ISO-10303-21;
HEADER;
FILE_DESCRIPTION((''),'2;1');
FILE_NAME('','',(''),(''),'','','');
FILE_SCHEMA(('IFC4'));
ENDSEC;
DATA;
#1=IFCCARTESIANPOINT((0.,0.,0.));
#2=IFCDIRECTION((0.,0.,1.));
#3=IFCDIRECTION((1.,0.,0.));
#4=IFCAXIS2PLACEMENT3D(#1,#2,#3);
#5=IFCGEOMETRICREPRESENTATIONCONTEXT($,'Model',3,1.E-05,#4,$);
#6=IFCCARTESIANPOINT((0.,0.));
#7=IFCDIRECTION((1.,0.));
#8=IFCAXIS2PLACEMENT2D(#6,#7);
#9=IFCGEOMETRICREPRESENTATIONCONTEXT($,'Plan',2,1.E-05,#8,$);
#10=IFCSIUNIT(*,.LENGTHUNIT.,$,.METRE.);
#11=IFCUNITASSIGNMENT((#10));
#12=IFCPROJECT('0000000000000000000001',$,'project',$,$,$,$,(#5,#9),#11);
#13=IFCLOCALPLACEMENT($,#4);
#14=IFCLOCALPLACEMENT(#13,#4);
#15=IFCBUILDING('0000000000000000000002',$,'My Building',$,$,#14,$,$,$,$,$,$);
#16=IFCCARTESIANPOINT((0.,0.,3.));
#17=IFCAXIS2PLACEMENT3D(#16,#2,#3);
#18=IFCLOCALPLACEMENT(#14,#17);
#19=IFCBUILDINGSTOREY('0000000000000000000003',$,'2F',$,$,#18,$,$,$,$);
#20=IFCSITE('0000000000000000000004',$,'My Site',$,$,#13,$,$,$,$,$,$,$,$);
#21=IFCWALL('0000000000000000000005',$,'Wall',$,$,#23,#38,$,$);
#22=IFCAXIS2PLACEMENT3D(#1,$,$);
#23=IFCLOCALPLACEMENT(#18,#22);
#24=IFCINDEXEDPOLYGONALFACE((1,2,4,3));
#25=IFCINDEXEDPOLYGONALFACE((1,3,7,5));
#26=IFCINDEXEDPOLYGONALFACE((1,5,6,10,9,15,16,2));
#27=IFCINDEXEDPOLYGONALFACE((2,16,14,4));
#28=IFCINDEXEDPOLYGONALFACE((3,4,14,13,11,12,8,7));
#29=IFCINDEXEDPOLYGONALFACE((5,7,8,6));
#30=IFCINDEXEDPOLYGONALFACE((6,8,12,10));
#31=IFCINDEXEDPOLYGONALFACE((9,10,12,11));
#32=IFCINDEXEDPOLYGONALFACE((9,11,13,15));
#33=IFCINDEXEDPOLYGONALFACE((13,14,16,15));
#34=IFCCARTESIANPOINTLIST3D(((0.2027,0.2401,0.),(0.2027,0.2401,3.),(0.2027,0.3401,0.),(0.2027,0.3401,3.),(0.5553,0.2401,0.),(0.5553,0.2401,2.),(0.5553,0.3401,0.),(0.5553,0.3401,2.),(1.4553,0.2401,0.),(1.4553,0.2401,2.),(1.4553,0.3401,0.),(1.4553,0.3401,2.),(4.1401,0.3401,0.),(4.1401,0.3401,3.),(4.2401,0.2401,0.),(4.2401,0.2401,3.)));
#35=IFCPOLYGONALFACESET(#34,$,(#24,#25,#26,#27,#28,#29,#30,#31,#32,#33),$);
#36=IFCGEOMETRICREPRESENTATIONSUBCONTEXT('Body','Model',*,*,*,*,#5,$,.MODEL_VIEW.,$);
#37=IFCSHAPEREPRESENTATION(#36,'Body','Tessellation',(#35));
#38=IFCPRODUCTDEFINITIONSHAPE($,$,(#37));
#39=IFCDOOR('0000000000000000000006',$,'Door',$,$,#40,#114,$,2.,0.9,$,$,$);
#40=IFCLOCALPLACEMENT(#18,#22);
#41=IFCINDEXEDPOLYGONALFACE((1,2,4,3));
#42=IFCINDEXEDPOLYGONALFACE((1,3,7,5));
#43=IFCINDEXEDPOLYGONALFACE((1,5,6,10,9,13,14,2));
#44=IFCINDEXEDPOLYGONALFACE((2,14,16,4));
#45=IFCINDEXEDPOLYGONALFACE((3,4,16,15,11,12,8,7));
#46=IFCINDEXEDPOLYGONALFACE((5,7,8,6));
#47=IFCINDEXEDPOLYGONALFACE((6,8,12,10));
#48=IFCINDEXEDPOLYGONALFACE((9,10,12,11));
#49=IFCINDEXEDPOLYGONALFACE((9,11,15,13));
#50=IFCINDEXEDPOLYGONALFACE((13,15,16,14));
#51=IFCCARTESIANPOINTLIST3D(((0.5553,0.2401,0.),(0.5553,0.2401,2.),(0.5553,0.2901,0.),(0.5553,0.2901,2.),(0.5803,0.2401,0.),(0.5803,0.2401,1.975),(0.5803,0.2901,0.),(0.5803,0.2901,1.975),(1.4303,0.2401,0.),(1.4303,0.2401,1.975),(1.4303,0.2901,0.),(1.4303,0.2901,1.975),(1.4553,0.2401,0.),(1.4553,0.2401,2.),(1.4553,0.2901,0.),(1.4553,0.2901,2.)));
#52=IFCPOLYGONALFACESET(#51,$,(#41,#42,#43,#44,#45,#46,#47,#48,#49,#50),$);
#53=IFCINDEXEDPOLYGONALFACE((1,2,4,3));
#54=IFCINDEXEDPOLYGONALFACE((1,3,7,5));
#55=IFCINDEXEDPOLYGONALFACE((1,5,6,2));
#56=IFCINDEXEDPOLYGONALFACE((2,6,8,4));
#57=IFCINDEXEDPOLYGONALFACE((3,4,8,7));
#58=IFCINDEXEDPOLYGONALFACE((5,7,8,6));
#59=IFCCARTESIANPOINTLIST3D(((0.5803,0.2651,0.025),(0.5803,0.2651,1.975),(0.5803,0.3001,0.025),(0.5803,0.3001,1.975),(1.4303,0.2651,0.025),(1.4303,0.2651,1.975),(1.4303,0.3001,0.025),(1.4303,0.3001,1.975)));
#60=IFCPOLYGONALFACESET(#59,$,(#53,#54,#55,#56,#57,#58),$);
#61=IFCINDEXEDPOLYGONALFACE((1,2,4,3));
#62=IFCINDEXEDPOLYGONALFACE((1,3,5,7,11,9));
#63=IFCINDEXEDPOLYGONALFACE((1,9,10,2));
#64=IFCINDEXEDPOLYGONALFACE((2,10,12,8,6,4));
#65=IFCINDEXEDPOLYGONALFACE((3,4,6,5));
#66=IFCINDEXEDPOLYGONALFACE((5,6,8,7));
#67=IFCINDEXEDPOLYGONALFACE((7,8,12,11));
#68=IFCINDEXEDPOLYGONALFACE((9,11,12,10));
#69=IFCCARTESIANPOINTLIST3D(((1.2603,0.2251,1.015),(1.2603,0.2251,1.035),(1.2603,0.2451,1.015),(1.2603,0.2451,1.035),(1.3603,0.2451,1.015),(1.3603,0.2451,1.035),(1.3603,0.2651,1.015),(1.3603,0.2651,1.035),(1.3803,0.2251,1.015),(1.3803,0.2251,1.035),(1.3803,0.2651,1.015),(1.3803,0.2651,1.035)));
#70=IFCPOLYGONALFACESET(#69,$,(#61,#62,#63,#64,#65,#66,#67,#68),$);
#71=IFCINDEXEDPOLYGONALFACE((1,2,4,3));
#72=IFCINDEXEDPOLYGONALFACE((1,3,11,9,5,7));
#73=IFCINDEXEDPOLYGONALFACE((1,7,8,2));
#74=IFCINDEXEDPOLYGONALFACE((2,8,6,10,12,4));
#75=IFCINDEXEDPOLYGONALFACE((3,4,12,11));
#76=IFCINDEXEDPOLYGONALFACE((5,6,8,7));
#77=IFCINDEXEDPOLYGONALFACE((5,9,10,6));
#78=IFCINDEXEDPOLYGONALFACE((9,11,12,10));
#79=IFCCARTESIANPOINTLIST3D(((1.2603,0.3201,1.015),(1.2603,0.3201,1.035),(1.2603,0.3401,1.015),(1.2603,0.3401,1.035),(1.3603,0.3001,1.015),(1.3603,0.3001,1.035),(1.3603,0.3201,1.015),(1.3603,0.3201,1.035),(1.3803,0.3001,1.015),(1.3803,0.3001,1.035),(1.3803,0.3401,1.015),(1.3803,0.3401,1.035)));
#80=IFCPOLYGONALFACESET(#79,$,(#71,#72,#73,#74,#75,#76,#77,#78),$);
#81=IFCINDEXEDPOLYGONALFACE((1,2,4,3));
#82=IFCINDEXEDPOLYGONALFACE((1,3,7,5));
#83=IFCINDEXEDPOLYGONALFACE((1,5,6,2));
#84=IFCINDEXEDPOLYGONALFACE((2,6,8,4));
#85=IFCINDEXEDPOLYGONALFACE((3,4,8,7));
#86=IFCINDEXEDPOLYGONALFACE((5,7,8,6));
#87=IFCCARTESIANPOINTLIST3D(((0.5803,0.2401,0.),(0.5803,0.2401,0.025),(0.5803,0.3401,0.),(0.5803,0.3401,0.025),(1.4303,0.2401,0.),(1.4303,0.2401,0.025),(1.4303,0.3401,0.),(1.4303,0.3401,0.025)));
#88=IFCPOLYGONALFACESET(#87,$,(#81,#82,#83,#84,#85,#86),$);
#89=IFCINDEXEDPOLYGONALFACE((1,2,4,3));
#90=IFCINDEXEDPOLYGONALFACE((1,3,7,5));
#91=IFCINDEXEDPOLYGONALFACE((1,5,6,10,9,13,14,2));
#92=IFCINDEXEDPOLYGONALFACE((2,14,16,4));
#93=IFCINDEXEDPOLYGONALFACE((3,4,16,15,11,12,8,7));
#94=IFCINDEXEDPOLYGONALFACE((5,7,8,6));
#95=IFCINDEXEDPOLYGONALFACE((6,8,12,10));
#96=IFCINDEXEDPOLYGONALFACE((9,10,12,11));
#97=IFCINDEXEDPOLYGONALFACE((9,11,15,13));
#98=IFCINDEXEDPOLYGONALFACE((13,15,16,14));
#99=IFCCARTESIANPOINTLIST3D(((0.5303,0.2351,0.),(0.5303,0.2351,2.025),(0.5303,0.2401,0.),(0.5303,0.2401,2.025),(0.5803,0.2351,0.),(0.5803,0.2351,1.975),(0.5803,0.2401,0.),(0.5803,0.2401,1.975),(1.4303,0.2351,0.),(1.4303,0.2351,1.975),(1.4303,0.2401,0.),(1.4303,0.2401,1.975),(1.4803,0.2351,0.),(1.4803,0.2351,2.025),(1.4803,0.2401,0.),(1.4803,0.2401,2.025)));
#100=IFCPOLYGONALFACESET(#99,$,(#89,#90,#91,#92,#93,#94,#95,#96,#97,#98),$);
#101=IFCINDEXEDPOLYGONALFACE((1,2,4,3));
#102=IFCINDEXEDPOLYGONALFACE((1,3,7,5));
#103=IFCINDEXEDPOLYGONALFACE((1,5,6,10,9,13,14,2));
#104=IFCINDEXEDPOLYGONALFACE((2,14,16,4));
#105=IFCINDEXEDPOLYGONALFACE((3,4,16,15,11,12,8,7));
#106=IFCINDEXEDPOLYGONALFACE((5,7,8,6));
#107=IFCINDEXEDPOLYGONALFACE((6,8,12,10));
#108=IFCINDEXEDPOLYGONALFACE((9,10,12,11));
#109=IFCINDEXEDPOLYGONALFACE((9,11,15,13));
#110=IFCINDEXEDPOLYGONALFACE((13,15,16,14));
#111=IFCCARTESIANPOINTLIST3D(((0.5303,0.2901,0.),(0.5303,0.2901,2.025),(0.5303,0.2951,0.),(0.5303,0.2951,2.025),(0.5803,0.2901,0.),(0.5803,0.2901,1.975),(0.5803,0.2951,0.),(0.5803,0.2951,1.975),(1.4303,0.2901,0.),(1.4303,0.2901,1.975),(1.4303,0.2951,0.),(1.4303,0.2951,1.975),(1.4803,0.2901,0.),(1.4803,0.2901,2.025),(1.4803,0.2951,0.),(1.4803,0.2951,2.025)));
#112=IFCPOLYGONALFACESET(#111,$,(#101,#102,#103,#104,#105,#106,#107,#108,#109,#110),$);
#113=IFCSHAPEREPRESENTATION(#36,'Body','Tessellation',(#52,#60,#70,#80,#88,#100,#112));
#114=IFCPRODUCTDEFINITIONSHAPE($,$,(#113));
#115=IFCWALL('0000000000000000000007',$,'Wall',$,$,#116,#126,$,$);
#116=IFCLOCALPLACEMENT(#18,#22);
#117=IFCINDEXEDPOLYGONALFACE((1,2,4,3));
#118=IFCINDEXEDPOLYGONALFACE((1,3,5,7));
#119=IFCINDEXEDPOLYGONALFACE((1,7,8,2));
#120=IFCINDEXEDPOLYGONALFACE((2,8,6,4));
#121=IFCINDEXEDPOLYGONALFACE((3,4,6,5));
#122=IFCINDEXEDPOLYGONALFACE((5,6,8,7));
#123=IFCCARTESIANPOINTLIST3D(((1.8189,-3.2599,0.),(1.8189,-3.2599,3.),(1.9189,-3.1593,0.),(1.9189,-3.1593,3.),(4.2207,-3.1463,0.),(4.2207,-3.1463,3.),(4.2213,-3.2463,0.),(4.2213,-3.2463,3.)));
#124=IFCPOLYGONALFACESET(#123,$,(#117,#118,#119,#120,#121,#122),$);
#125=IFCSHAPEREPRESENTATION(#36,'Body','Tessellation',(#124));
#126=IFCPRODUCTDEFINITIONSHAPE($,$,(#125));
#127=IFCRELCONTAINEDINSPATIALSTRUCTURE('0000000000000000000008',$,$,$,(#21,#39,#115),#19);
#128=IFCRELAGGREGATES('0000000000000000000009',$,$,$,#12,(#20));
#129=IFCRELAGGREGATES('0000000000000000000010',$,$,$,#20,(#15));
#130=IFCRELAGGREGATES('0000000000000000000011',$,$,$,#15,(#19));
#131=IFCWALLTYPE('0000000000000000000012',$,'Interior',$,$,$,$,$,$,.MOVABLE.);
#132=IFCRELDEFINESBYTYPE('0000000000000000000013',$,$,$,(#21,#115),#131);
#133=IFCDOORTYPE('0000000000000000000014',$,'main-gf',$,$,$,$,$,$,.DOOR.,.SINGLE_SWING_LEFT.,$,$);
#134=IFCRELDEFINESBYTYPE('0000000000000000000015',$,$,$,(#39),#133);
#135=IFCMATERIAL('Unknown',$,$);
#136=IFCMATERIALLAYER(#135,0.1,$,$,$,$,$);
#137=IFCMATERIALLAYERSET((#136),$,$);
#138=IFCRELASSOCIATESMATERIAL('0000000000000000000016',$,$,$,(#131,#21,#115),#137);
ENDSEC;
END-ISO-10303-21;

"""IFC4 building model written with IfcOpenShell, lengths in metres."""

from ifc_helpers import new_model, entity, si_unit, frame, origin_with_axes, origin_2d_with_axis, place, context, subcontext, project, spatial, line, indexed_curve, outline, extrude, shape, source, transform, mapped, material, layer, layer_set, layer_usage, type_object, type_shapes, element, fill, save


model = new_model("IFC4")

# Units and contexts
model_context = context("Model", 3, precision=1e-05, world=origin_with_axes())
plan_context = context("Plan", 2, precision=1e-05, world=origin_2d_with_axis())
body_context_1 = subcontext(model_context, "Body", "Model", "MODEL_VIEW")
body_context_2 = subcontext(plan_context, "Body", "Plan", "PLAN_VIEW")
ifc_project = project(units=[si_unit("LENGTHUNIT", "METRE")], contexts=[model_context, plan_context])

# Site, building, storey
site_placement = place(None, origin_with_axes())
site = spatial("IfcSite", under=ifc_project, at=site_placement, Name="My Site")
building_placement = place(site_placement, origin_with_axes())
building = spatial("IfcBuilding", under=site, at=building_placement, Name="My Building")
storey_placement = place(building_placement, frame((0.0, 0.0, 3.0), z_axis=(0.0, 0.0, 1.0), x_axis=(1.0, 0.0, 0.0)))
storey = spatial("IfcBuildingStorey", under=building, at=storey_placement, Name="2F")

# Shared definitions
ifc_material = material(Name="Unknown")

# Shared definitions
ifc_layer_1 = layer(ifc_material, 0.1)
ifc_layer_set_1 = layer_set([ifc_layer_1])
wall_type = type_object("IfcWallType", Name="Interior", PredefinedType="MOVABLE", material=ifc_layer_set_1)

# Shared definitions
shared_shape_1 = source(origin_with_axes(), body_context_1, "Body", "SweptSolid", [
    extrude(outline(indexed_curve([(0.0, 0.0), (0.9, 0.0), (0.9, 2.0), (0.0, 2.0)], segments=[line(1, 2, 3, 4, 1)])), frame((0.0, -0.6, 0.0), z_axis=(0.0, -1.0, 0.0), x_axis=(1.0, 0.0, 0.0)), (0.0, 0.0, -1.0), 1.2),
])
door_type = type_object("IfcDoorType", Name="main-gf", OperationType="SINGLE_SWING_LEFT", PredefinedType="DOOR")
shared_shape_2 = source(origin_with_axes(), body_context_1, "Body", "SweptSolid", [
    extrude(outline(indexed_curve([(0.0, 0.0), (0.0, 2.0), (0.9, 2.0), (0.9, 0.0), (0.875, 0.0), (0.875, 1.975), (0.025, 1.975), (0.025, 0.0)], segments=[line(1, 2, 3, 4, 5, 6, 7, 8, 1)])), frame((0.0, 0.0, 0.0), z_axis=(0.0, -1.0, 0.0), x_axis=(1.0, 0.0, 0.0)), (0.0, 0.0, -1.0), 0.05),
    extrude(outline(indexed_curve([(0.0, 0.0), (0.85, 0.0), (0.85, 0.035), (0.0, 0.035)], segments=[line(1, 2, 3, 4, 1)])), frame((0.025, 0.025, 0.025), z_axis=(0.0, 0.0, 1.0), x_axis=(1.0, 0.0, 0.0)), (0.0, 0.0, 1.0), 1.95),
    extrude(outline(indexed_curve([(0.0, 0.0), (0.0, -0.04), (-0.12, -0.04), (-0.12, -0.02), (-0.02, -0.02), (-0.02, 0.0)], segments=[line(1, 2, 3, 4, 5, 6, 1)])), frame((0.825, 0.025, 1.015), z_axis=(0.0, 0.0, 1.0), x_axis=(1.0, 0.0, 0.0)), (0.0, 0.0, 1.0), 0.02),
    extrude(outline(indexed_curve([(0.0, 0.0), (0.0, 0.04), (-0.12, 0.04), (-0.12, 0.02), (-0.02, 0.02), (-0.02, 0.0)], segments=[line(1, 2, 3, 4, 5, 6, 1)])), frame((0.825, 0.06, 1.015), z_axis=(0.0, 0.0, 1.0), x_axis=(1.0, 0.0, 0.0)), (0.0, 0.0, 1.0), 0.02),
    extrude(outline(indexed_curve([(0.0, 0.0), (0.85, 0.0), (0.85, 0.1), (0.0, 0.1)], segments=[line(1, 2, 3, 4, 1)])), frame((0.025, 0.0, 0.0), z_axis=(0.0, 0.0, 1.0), x_axis=(1.0, 0.0, 0.0)), (0.0, 0.0, 1.0), 0.025),
    extrude(outline(indexed_curve([(0.0, 0.0), (0.0, 2.025), (0.95, 2.025), (0.95, 0.0), (0.9, 0.0), (0.9, 1.975), (0.05, 1.975), (0.05, 0.0)], segments=[line(1, 2, 3, 4, 5, 6, 7, 8, 1)])), frame((-0.025, -0.005, 0.0), z_axis=(0.0, -1.0, 0.0), x_axis=(1.0, 0.0, 0.0)), (0.0, 0.0, -1.0), 0.005),
    extrude(outline(indexed_curve([(0.0, 0.0), (0.0, 2.025), (0.95, 2.025), (0.95, 0.0), (0.9, 0.0), (0.9, 1.975), (0.05, 1.975), (0.05, 0.0)], segments=[line(1, 2, 3, 4, 5, 6, 7, 8, 1)])), frame((-0.025, 0.05, 0.0), z_axis=(0.0, -1.0, 0.0), x_axis=(1.0, 0.0, 0.0)), (0.0, 0.0, -1.0), 0.005),
])
shared_shape_3 = source(origin_with_axes(), body_context_2, "Body", "Curve2D", [
    entity("IfcIndexedPolyCurve", entity("IfcCartesianPointList2D", [[0.0, 0.0], [0.025, 0.0], [0.025, 0.05], [0.0, 0.05]]), [entity("IfcLineIndex", [1, 2, 3, 4, 1])]),
    entity("IfcIndexedPolyCurve", entity("IfcCartesianPointList2D", [[0.9, 0.0], [0.875, 0.0], [0.875, 0.05], [0.9, 0.05]]), [entity("IfcLineIndex", [1, 2, 3, 4, 1])]),
    entity("IfcIndexedPolyCurve", entity("IfcCartesianPointList2D", [[0.025, 0.05], [0.025, -0.8], [0.06, -0.8]])),
    entity("IfcTrimmedCurve", entity("IfcEllipse", entity("IfcAxis2Placement2D", entity("IfcCartesianPoint", [0.06, 0.05]), entity("IfcDirection", [1.0, 0.0])), 0.815, 0.85), [entity("IfcCartesianPoint", [0.06, -0.8])], [entity("IfcCartesianPoint", [0.06, 0.9])], True, "CARTESIAN"),
    entity("IfcIndexedPolyCurve", entity("IfcCartesianPointList2D", [[0.025, 0.05], [0.06, 0.05], [0.06, 0.9], [0.025, 0.9]]), [entity("IfcLineIndex", [1, 2, 3, 4, 1])]),
])
type_shapes(door_type, [shared_shape_2, shared_shape_3])

# Wall, opening, door
ifc_layer_usage_1 = layer_usage(ifc_layer_set_1, "AXIS2", "POSITIVE", 0.0)
wall_1_placement = place(storey_placement, frame((4.1401, 0.3401, 0.0), z_axis=(0.0, 0.0, 1.0), x_axis=(-1.0, 0.0, 0.0)))
wall_1 = element("IfcWall", 1, at=wall_1_placement, inside=storey, type_object=wall_type, material=ifc_layer_usage_1, Name="Wall", context=body_context_1, shape_type="SweptSolid", body=[
    extrude(outline(indexed_curve([(0.0, 0.0), (-0.1, 0.1), (3.9374, 0.1), (3.9374, 0.0)], segments=[line(1, 2, 3, 4, 1)])), origin_with_axes(), (0.0, 0.0, 1.0), 3.0),
])
opening_1_placement = place(wall_1_placement, frame((3.5848, 0.1, 0.0), z_axis=(0.0, 0.0, 1.0), x_axis=(-1.0, 0.0, 0.0)))
opening_1 = element("IfcOpeningElement", 2, at=opening_1_placement, cuts=wall_1, PredefinedType="OPENING", context=body_context_1, shape_type="MappedRepresentation", body=[
    mapped(shared_shape_1, transform((0.0, 0.0, 0.0), x_axis=(1.0, 0.0, 0.0), y_axis=(0.0, 1.0, 0.0), z_axis=(0.0, 0.0, 1.0), scale=1.0)),
])
door_1_placement = place(opening_1_placement, frame((0.0, 0.0, 0.0), z_axis=(0.0, 0.0, 1.0), x_axis=(1.0, 0.0, 0.0)))
door_1 = element("IfcDoor", 3, at=door_1_placement, inside=storey, type_object=door_type, Name="Door", OverallHeight=2.0, OverallWidth=0.9, shapes=[
    shape(body_context_1, "Body", "MappedRepresentation", [mapped(shared_shape_2, transform((0.0, 0.0, 0.0), x_axis=(1.0, 0.0, 0.0), y_axis=(0.0, 1.0, 0.0), z_axis=(0.0, 0.0, 1.0), scale=1.0))]),
    shape(body_context_2, "Body", "MappedRepresentation", [mapped(shared_shape_3, transform((0.0, 0.0, 0.0), x_axis=(1.0, 0.0, 0.0), y_axis=(0.0, 1.0, 0.0), z_axis=(0.0, 0.0, 1.0), scale=1.0))]),
])
fill(opening_1, door_1)

# Wall
ifc_layer_usage_2 = layer_usage(ifc_layer_set_1, "AXIS2", "POSITIVE", 0.0)
wall_2_placement = place(storey_placement, frame((1.9189, -3.2593, 0.0), z_axis=(0.0, 0.0, 1.0), x_axis=(0.999984, 0.005648, 0.0)))
element("IfcWall", 4, at=wall_2_placement, inside=storey, type_object=wall_type, material=ifc_layer_usage_2, Name="Wall", context=body_context_1, shape_type="SweptSolid", body=[
    extrude(outline(indexed_curve([(-0.1, 0.0), (0.0006, 0.1), (2.3024, 0.1), (2.3024, 0.0)], segments=[line(1, 2, 3, 4, 1)])), origin_with_axes(), (0.0, 0.0, 1.0), 3.0),
])

save(model, "model.ifc")
